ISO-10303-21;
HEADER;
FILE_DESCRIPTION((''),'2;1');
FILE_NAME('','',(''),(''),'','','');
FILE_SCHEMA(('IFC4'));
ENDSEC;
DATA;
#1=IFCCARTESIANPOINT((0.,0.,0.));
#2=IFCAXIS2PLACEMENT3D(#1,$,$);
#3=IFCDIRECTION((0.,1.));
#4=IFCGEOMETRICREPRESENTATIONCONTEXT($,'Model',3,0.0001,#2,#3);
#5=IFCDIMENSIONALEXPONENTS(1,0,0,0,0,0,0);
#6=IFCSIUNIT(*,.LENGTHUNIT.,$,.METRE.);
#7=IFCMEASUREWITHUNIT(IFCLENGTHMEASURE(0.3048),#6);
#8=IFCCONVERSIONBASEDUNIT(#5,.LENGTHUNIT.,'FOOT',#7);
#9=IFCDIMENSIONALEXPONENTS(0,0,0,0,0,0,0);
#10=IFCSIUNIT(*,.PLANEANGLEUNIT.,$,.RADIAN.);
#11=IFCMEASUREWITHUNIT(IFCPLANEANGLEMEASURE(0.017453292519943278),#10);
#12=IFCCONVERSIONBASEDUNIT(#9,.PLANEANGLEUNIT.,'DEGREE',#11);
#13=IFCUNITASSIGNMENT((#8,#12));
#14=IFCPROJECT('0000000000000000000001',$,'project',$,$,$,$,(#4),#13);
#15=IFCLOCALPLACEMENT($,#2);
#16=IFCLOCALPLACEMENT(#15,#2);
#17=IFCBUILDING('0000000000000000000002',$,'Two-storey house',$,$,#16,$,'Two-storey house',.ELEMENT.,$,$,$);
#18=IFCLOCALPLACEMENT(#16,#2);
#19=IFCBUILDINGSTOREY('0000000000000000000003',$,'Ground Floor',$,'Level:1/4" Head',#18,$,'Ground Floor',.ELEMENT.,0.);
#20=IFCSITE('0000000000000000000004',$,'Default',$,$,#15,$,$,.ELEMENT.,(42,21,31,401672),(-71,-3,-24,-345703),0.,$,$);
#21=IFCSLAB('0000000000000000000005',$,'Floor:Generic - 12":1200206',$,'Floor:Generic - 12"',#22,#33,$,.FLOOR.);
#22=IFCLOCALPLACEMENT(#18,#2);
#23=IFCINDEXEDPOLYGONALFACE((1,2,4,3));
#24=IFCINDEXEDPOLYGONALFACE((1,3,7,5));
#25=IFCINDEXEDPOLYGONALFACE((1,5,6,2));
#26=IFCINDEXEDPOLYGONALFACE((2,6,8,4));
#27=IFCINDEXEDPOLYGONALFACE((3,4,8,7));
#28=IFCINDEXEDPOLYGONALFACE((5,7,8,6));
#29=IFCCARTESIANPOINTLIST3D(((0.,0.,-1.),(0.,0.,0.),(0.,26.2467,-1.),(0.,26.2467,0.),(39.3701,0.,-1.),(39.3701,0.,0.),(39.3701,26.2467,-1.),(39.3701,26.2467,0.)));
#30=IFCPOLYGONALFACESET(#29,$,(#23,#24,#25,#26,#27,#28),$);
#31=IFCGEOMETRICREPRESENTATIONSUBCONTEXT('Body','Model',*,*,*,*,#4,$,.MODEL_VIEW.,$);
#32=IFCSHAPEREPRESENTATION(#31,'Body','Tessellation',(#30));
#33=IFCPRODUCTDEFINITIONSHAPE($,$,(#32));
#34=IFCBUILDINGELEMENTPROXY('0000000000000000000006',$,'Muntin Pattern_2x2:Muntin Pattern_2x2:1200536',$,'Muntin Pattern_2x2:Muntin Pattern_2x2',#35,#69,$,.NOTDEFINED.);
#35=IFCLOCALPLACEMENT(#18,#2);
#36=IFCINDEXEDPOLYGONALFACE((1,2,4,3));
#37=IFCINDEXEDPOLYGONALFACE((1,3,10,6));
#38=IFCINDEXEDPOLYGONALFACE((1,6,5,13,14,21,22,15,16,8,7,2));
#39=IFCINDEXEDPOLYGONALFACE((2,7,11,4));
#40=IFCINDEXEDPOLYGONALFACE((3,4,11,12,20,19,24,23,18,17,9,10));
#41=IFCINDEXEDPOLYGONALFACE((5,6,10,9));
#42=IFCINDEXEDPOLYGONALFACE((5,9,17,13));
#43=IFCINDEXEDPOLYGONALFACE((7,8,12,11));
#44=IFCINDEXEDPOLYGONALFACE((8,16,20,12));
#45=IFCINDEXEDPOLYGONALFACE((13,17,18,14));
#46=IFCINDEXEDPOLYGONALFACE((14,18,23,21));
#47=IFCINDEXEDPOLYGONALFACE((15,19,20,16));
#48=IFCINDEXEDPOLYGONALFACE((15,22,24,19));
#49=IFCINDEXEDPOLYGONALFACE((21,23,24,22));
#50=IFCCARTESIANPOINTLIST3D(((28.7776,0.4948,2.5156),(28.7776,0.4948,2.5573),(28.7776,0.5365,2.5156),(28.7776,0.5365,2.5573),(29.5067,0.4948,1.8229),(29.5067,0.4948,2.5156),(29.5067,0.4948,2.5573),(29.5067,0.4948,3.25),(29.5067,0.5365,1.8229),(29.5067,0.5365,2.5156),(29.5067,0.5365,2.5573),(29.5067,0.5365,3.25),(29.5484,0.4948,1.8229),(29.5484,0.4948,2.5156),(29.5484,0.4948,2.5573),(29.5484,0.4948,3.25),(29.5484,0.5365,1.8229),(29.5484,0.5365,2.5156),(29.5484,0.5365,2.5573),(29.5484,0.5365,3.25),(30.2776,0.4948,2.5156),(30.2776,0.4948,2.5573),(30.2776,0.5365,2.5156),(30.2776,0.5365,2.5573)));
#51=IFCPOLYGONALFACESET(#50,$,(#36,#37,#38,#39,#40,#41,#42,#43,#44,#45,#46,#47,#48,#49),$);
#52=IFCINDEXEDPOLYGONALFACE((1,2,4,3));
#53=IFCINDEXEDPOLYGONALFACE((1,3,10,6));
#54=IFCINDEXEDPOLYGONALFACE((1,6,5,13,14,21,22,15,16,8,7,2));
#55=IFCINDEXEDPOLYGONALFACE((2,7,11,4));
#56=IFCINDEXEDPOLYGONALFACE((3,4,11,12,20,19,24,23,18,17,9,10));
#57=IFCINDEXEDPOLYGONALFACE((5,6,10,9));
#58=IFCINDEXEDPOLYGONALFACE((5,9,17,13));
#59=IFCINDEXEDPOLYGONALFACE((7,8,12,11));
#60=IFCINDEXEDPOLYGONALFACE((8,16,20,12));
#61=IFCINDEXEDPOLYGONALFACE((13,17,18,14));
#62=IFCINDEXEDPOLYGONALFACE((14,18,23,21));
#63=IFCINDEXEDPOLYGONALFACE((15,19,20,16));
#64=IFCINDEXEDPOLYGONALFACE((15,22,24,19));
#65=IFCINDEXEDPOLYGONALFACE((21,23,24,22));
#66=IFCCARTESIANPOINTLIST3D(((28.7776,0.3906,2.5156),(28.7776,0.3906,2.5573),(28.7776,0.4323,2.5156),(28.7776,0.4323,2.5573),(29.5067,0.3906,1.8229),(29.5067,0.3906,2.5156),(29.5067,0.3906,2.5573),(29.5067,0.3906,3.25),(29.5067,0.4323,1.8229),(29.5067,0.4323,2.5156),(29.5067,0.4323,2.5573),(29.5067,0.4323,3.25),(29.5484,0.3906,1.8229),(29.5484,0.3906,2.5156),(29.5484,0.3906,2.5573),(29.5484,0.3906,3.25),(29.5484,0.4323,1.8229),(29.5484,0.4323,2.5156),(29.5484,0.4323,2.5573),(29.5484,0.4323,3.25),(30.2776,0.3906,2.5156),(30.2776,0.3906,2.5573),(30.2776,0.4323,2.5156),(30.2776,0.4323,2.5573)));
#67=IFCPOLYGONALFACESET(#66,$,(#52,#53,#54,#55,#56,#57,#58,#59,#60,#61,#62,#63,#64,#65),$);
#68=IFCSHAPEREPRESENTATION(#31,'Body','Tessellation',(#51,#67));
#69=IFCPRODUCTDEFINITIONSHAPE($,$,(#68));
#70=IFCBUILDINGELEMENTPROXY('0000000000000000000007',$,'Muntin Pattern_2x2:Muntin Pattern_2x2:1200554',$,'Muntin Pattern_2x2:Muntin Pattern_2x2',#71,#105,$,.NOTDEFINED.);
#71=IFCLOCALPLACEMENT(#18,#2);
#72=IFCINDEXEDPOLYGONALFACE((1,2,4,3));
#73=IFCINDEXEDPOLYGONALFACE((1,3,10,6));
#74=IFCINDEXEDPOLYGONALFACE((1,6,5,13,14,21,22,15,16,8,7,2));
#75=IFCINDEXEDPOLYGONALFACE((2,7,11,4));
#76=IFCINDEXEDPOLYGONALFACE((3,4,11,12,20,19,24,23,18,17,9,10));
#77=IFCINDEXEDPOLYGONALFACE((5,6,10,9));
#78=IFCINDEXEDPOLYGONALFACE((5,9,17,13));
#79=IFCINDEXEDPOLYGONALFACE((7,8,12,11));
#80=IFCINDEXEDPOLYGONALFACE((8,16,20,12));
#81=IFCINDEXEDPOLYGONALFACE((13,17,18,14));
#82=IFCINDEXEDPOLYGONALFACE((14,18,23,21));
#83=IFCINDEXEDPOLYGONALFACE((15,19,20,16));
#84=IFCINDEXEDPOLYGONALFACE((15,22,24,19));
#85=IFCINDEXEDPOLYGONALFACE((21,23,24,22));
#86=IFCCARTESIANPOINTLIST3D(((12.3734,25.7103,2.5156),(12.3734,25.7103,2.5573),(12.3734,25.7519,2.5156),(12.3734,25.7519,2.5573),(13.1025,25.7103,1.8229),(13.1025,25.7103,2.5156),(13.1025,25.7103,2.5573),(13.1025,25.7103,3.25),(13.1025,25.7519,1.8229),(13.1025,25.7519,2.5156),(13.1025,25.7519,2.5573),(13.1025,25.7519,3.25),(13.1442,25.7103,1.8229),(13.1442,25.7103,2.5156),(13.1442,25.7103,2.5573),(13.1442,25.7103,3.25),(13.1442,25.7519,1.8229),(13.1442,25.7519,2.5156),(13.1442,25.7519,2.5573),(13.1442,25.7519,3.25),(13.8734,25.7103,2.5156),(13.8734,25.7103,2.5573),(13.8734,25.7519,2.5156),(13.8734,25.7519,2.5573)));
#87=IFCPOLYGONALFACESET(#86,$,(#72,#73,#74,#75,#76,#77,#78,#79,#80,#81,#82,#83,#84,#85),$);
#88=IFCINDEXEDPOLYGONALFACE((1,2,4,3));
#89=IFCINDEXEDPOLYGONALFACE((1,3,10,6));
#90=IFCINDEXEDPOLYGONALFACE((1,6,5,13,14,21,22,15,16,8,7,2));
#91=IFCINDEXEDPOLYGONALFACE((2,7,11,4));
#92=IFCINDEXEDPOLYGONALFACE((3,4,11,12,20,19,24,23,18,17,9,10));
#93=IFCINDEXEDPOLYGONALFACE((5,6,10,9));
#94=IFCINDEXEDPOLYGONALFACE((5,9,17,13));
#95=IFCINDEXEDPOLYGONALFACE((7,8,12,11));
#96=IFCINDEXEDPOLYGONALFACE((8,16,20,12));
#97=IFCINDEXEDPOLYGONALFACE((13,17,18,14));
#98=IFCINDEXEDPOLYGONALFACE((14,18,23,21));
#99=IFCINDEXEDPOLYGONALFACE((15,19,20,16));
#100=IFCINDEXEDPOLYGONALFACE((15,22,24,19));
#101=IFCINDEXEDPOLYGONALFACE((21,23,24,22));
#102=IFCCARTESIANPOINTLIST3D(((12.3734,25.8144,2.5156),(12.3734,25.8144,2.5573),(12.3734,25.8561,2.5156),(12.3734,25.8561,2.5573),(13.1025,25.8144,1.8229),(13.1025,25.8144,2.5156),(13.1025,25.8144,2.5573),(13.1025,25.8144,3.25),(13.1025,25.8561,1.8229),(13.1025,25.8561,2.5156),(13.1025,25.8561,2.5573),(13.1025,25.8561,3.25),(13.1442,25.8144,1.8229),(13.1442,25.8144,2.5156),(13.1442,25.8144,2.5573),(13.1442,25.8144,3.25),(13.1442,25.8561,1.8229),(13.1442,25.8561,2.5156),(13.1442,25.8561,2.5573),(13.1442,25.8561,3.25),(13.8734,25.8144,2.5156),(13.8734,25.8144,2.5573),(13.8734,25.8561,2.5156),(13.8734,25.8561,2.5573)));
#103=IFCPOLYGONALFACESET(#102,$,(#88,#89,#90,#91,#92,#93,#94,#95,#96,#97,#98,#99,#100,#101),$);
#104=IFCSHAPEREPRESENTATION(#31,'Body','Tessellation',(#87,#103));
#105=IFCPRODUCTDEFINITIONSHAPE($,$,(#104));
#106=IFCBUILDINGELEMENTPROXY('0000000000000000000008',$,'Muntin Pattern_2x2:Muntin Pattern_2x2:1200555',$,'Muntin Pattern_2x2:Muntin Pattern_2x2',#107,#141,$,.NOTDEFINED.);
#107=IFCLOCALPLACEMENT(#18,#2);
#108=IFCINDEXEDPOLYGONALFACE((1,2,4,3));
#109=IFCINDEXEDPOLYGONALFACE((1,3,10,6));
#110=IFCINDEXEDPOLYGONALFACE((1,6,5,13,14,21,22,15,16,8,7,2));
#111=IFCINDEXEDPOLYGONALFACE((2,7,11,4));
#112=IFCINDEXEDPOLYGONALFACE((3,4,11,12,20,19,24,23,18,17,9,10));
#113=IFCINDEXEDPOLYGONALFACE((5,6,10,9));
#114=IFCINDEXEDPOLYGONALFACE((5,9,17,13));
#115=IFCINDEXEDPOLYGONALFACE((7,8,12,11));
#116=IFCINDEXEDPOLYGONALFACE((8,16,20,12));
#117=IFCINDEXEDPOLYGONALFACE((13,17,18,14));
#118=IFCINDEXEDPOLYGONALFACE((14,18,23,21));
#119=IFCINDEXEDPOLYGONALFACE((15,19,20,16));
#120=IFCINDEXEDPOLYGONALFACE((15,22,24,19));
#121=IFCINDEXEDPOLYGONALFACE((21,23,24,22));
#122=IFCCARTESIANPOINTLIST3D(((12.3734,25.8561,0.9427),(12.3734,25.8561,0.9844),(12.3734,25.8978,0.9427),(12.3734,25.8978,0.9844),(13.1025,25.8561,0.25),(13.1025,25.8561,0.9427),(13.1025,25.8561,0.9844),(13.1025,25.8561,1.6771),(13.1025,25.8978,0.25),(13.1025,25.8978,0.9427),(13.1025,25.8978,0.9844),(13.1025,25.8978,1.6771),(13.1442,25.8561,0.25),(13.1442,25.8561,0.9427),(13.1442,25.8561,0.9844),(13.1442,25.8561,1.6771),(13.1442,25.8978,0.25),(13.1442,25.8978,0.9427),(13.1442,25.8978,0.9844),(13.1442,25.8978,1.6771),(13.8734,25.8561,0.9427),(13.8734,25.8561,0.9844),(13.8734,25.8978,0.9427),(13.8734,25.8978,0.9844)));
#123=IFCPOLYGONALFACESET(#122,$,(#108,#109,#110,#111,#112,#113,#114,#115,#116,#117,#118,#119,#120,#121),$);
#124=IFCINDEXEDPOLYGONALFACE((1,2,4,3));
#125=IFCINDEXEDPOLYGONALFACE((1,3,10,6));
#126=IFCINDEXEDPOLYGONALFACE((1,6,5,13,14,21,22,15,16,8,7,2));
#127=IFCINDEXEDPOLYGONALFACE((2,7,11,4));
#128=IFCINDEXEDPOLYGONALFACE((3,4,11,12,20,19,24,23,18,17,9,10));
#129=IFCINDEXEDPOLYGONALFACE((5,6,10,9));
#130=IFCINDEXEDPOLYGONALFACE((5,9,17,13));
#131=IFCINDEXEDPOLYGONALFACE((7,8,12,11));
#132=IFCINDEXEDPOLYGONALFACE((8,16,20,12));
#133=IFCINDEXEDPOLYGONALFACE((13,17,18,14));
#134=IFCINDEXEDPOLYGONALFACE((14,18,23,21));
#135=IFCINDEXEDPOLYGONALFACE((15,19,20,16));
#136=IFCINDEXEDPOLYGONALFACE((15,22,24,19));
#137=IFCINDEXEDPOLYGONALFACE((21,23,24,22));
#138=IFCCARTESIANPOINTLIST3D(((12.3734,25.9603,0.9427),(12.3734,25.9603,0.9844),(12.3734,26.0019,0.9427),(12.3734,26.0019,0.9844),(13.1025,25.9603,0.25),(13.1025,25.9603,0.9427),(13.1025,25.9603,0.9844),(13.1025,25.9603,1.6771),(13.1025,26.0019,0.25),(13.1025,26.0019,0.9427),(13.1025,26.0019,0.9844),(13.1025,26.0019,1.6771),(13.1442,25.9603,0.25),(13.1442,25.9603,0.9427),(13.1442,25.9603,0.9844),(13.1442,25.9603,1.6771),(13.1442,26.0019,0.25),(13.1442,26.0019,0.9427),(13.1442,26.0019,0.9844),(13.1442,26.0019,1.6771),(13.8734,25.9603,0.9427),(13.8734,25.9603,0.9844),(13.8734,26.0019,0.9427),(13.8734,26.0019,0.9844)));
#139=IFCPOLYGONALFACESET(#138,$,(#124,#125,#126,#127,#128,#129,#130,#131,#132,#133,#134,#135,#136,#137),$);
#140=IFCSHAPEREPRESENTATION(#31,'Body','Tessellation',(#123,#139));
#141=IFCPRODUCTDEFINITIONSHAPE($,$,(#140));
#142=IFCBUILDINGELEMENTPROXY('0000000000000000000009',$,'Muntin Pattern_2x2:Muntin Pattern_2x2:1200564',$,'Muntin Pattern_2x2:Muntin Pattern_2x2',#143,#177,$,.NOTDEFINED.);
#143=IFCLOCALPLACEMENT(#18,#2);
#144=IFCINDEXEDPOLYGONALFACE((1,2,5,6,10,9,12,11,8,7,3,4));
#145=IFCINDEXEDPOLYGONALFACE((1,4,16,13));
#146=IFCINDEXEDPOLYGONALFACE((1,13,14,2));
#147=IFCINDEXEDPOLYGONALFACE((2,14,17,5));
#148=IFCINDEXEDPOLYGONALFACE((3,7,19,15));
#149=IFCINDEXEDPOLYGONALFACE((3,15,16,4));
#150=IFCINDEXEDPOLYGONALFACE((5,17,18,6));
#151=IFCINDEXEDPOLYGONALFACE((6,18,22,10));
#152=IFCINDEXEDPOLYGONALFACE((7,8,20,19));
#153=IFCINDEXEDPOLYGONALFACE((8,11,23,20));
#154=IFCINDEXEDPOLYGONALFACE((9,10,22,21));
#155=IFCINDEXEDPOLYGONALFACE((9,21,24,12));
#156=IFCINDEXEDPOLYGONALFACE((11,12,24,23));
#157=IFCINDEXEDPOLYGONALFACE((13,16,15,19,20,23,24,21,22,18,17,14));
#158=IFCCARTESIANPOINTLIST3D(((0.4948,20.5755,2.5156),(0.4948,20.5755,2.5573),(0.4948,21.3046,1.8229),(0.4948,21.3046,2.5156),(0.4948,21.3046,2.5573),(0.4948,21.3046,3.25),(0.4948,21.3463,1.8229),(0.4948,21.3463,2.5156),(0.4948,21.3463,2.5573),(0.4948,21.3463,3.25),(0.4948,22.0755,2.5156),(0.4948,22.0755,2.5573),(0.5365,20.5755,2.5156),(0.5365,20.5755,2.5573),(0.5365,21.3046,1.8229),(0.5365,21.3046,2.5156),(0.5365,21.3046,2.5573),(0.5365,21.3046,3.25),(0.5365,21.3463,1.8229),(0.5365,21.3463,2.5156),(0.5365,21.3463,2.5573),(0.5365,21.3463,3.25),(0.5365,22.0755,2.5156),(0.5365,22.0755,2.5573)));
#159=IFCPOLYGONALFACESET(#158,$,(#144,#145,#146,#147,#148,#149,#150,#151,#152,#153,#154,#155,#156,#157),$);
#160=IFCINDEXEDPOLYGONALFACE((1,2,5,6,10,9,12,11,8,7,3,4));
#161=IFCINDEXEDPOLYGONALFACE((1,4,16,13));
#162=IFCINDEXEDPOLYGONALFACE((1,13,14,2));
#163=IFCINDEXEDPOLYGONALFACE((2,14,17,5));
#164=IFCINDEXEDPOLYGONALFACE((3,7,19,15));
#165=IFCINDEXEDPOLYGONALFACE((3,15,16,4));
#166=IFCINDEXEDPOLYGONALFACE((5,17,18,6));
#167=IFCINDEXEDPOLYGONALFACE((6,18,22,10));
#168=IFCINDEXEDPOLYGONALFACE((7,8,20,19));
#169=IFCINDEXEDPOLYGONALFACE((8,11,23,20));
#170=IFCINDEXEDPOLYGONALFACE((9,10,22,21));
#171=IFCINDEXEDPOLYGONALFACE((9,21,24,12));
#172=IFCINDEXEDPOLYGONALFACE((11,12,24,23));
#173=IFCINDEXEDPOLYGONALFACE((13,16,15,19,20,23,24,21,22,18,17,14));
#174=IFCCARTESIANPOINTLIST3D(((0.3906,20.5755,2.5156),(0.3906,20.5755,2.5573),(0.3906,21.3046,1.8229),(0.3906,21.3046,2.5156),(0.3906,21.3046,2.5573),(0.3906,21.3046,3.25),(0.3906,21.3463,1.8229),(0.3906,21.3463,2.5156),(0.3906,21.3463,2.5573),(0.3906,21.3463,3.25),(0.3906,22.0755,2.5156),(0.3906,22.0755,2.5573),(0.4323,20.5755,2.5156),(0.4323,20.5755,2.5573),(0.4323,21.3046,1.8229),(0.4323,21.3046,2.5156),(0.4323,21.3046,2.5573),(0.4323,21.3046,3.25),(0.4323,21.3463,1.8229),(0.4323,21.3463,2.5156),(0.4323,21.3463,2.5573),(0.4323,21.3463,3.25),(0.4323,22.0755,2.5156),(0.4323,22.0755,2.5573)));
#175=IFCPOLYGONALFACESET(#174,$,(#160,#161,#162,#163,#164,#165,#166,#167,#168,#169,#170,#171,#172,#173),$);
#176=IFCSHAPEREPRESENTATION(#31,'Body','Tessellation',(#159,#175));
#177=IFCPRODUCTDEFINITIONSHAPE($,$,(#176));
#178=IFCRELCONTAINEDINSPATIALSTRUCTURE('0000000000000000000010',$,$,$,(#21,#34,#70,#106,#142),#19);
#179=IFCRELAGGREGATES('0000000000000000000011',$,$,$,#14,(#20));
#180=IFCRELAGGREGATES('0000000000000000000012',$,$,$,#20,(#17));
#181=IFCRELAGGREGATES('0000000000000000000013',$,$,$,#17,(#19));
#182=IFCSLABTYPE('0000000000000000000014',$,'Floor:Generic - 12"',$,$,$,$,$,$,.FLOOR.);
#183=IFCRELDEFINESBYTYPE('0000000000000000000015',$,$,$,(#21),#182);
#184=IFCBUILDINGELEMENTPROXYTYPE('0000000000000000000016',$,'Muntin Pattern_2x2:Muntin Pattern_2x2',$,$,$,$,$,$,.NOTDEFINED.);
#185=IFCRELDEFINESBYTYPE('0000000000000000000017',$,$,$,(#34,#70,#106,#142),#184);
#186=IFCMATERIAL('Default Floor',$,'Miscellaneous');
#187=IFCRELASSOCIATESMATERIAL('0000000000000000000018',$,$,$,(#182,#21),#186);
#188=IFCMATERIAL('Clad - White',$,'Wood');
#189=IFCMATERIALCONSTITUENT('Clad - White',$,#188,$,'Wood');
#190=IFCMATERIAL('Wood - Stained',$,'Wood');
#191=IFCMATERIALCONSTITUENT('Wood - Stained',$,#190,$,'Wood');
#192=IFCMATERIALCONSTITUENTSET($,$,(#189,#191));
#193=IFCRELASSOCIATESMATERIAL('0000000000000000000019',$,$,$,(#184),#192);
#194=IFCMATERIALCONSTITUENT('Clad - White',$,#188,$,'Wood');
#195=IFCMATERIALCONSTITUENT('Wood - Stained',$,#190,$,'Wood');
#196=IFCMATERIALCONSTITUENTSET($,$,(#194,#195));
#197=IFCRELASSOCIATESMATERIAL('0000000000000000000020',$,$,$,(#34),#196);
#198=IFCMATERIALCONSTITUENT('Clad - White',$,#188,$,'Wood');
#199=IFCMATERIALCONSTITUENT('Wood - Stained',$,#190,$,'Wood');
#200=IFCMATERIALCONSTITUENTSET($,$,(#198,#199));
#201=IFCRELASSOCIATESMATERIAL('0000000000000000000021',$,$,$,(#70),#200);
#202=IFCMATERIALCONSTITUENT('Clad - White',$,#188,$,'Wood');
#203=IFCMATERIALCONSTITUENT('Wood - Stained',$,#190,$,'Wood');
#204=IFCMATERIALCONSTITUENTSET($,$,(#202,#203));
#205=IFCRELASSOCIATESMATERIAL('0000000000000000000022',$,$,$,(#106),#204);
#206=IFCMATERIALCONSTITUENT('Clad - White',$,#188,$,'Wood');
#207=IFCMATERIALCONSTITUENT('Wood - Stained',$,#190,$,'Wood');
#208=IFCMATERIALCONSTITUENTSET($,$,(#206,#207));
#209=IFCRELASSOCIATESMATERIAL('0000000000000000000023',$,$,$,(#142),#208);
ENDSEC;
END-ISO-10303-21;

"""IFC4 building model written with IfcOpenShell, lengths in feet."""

from ifc_helpers import new_model, entity, si_unit, converted_unit, direction, frame, origin, place, context, subcontext, project, spatial, indexed_curve, outline, extrude, source, transform, mapped, material, constituent, constituent_set, type_object, type_shapes, element, save


model = new_model("IFC4")

# Units and contexts
model_context = context("Model", 3, precision=0.0001, world=origin(), true_north=direction((0.0, 1.0)))
body_context = subcontext(model_context, "Body", "Model", "MODEL_VIEW")
ifc_project = project(units=[converted_unit("LENGTHUNIT", "FOOT", entity("IfcLengthMeasure", 0.3048), si_unit("LENGTHUNIT", "METRE"), dimensions=[1, 0, 0, 0, 0, 0, 0]), converted_unit("PLANEANGLEUNIT", "DEGREE", entity("IfcPlaneAngleMeasure", 0.017453292519943278), si_unit("PLANEANGLEUNIT", "RADIAN"), dimensions=[0, 0, 0, 0, 0, 0, 0])], contexts=[model_context])

# Site, building, storey
site_placement = place(None, origin())
site = spatial("IfcSite", under=ifc_project, at=site_placement, Name="Default", CompositionType="ELEMENT", RefLatitude=(42, 21, 31, 401672), RefLongitude=(-71, -3, -24, -345703), RefElevation=0.0)
building_placement = place(site_placement, origin())
building = spatial("IfcBuilding", under=site, at=building_placement, Name="Two-storey house", LongName="Two-storey house", CompositionType="ELEMENT")
storey_placement = place(building_placement, origin())
storey = spatial("IfcBuildingStorey", under=building, at=storey_placement, Name="Ground Floor", ObjectType="Level:1/4\" Head", LongName="Ground Floor", CompositionType="ELEMENT", Elevation=0.0)

# Slab
ifc_material_1 = material(Name="Default Floor", Category="Miscellaneous")
slab_type = type_object("IfcSlabType", Name="Floor:Generic - 12\"", PredefinedType="FLOOR", material=ifc_material_1)
slab_placement = place(storey_placement, origin())
element("IfcSlab", 1, at=slab_placement, inside=storey, type_object=slab_type, material=ifc_material_1, Name="Floor:Generic - 12\":1200206", ObjectType="Floor:Generic - 12\"", PredefinedType="FLOOR", context=body_context, shape_type="SweptSolid", body=[
    extrude(outline(indexed_curve([(-13.1234, -19.685), (13.1234, -19.685), (13.1234, 19.685), (-13.1234, 19.685), (-13.1234, -19.685)], self_intersect=False)), frame((19.685, 13.1234, 0.0), z_axis=(0.0, 0.0, -1.0), x_axis=(0.0, 1.0, 0.0)), (0.0, 0.0, 1.0), 1.0),
])

# Shared definitions
ifc_material_2 = material(Name="Wood - Stained", Category="Wood")

# Building element proxies
ifc_material_3 = material(Name="Clad - White", Category="Wood")
ifc_constituent_1 = constituent(ifc_material_3, Name="Clad - White", Category="Wood")
ifc_constituent_2 = constituent(ifc_material_2, Name="Wood - Stained", Category="Wood")
ifc_constituent_set_1 = constituent_set(constituents=[ifc_constituent_1, ifc_constituent_2])
ifc_constituent_3 = constituent(ifc_material_3, Name="Clad - White", Category="Wood")
ifc_constituent_4 = constituent(ifc_material_2, Name="Wood - Stained", Category="Wood")
ifc_constituent_set_2 = constituent_set(constituents=[ifc_constituent_3, ifc_constituent_4])
building_element_proxy_type_1 = type_object("IfcBuildingElementProxyType", Name="Muntin Pattern_2x2:Muntin Pattern_2x2", PredefinedType="NOTDEFINED", material=ifc_constituent_set_2)
shared_shape_1 = source(origin(), body_context, "Body", "SweptSolid", [
    extrude(outline(indexed_curve([(0.0208, -0.0208), (0.7135, -0.0208), (0.7135, 0.0208), (0.0208, 0.0208), (0.0208, 0.75), (-0.0208, 0.75), (-0.0208, 0.0208), (-0.7135, 0.0208), (-0.7135, -0.0208), (-0.0208, -0.0208), (-0.0208, -0.75), (0.0208, -0.75), (0.0208, -0.0208)], self_intersect=False)), frame((0.0, 0.0312, 0.7135), z_axis=(0.0, 1.0, 0.0), x_axis=(0.0, 0.0, 1.0)), (0.0, 0.0, 1.0), 0.0417),
    extrude(outline(indexed_curve([(0.0208, -0.0208), (0.7135, -0.0208), (0.7135, 0.0208), (0.0208, 0.0208), (0.0208, 0.75), (-0.0208, 0.75), (-0.0208, 0.0208), (-0.7135, 0.0208), (-0.7135, -0.0208), (-0.0208, -0.0208), (-0.0208, -0.75), (0.0208, -0.75), (0.0208, -0.0208)], self_intersect=False)), frame((0.0, -0.0729, 0.7135), z_axis=(0.0, 1.0, 0.0), x_axis=(0.0, 0.0, 1.0)), (0.0, 0.0, 1.0), 0.0417),
])
type_shapes(building_element_proxy_type_1, [shared_shape_1])
proxy_1_placement = place(storey_placement, frame((29.5276, 0.4635, 1.8229)))
element("IfcBuildingElementProxy", 2, at=proxy_1_placement, inside=storey, type_object=building_element_proxy_type_1, material=ifc_constituent_set_1, Name="Muntin Pattern_2x2:Muntin Pattern_2x2:1200536", ObjectType="Muntin Pattern_2x2:Muntin Pattern_2x2", PredefinedType="NOTDEFINED", context=body_context, shape_type="MappedRepresentation", body=[
    mapped(shared_shape_1, transform((0.0, 0.0, 0.0), scale=1.0)),
])
ifc_constituent_5 = constituent(ifc_material_3, Name="Clad - White", Category="Wood")
ifc_constituent_6 = constituent(ifc_material_2, Name="Wood - Stained", Category="Wood")
ifc_constituent_set_3 = constituent_set(constituents=[ifc_constituent_5, ifc_constituent_6])
proxy_2_placement = place(storey_placement, frame((13.1234, 25.7832, 1.8229), z_axis=(0.0, 0.0, 1.0), x_axis=(-1.0, 0.0, 0.0)))
element("IfcBuildingElementProxy", 3, at=proxy_2_placement, inside=storey, type_object=building_element_proxy_type_1, material=ifc_constituent_set_3, Name="Muntin Pattern_2x2:Muntin Pattern_2x2:1200554", ObjectType="Muntin Pattern_2x2:Muntin Pattern_2x2", PredefinedType="NOTDEFINED", context=body_context, shape_type="MappedRepresentation", body=[
    mapped(shared_shape_1, transform((0.0, 0.0, 0.0), scale=1.0)),
])
ifc_constituent_7 = constituent(ifc_material_3, Name="Clad - White", Category="Wood")
ifc_constituent_8 = constituent(ifc_material_2, Name="Wood - Stained", Category="Wood")
ifc_constituent_set_4 = constituent_set(constituents=[ifc_constituent_7, ifc_constituent_8])
proxy_3_placement = place(storey_placement, frame((13.1234, 25.929, 0.25), z_axis=(0.0, 0.0, 1.0), x_axis=(-1.0, 0.0, 0.0)))
element("IfcBuildingElementProxy", 4, at=proxy_3_placement, inside=storey, type_object=building_element_proxy_type_1, material=ifc_constituent_set_4, Name="Muntin Pattern_2x2:Muntin Pattern_2x2:1200555", ObjectType="Muntin Pattern_2x2:Muntin Pattern_2x2", PredefinedType="NOTDEFINED", context=body_context, shape_type="MappedRepresentation", body=[
    mapped(shared_shape_1, transform((0.0, 0.0, 0.0), scale=1.0)),
])
ifc_constituent_9 = constituent(ifc_material_3, Name="Clad - White", Category="Wood")
ifc_constituent_10 = constituent(ifc_material_2, Name="Wood - Stained", Category="Wood")
ifc_constituent_set_5 = constituent_set(constituents=[ifc_constituent_9, ifc_constituent_10])
proxy_4_placement = place(storey_placement, frame((0.4635, 21.3255, 1.8229), z_axis=(0.0, 0.0, 1.0), x_axis=(0.0, -1.0, 0.0)))
element("IfcBuildingElementProxy", 5, at=proxy_4_placement, inside=storey, type_object=building_element_proxy_type_1, material=ifc_constituent_set_5, Name="Muntin Pattern_2x2:Muntin Pattern_2x2:1200564", ObjectType="Muntin Pattern_2x2:Muntin Pattern_2x2", PredefinedType="NOTDEFINED", context=body_context, shape_type="MappedRepresentation", body=[
    mapped(shared_shape_1, transform((0.0, 0.0, 0.0), scale=1.0)),
])

save(model, "model.ifc")
